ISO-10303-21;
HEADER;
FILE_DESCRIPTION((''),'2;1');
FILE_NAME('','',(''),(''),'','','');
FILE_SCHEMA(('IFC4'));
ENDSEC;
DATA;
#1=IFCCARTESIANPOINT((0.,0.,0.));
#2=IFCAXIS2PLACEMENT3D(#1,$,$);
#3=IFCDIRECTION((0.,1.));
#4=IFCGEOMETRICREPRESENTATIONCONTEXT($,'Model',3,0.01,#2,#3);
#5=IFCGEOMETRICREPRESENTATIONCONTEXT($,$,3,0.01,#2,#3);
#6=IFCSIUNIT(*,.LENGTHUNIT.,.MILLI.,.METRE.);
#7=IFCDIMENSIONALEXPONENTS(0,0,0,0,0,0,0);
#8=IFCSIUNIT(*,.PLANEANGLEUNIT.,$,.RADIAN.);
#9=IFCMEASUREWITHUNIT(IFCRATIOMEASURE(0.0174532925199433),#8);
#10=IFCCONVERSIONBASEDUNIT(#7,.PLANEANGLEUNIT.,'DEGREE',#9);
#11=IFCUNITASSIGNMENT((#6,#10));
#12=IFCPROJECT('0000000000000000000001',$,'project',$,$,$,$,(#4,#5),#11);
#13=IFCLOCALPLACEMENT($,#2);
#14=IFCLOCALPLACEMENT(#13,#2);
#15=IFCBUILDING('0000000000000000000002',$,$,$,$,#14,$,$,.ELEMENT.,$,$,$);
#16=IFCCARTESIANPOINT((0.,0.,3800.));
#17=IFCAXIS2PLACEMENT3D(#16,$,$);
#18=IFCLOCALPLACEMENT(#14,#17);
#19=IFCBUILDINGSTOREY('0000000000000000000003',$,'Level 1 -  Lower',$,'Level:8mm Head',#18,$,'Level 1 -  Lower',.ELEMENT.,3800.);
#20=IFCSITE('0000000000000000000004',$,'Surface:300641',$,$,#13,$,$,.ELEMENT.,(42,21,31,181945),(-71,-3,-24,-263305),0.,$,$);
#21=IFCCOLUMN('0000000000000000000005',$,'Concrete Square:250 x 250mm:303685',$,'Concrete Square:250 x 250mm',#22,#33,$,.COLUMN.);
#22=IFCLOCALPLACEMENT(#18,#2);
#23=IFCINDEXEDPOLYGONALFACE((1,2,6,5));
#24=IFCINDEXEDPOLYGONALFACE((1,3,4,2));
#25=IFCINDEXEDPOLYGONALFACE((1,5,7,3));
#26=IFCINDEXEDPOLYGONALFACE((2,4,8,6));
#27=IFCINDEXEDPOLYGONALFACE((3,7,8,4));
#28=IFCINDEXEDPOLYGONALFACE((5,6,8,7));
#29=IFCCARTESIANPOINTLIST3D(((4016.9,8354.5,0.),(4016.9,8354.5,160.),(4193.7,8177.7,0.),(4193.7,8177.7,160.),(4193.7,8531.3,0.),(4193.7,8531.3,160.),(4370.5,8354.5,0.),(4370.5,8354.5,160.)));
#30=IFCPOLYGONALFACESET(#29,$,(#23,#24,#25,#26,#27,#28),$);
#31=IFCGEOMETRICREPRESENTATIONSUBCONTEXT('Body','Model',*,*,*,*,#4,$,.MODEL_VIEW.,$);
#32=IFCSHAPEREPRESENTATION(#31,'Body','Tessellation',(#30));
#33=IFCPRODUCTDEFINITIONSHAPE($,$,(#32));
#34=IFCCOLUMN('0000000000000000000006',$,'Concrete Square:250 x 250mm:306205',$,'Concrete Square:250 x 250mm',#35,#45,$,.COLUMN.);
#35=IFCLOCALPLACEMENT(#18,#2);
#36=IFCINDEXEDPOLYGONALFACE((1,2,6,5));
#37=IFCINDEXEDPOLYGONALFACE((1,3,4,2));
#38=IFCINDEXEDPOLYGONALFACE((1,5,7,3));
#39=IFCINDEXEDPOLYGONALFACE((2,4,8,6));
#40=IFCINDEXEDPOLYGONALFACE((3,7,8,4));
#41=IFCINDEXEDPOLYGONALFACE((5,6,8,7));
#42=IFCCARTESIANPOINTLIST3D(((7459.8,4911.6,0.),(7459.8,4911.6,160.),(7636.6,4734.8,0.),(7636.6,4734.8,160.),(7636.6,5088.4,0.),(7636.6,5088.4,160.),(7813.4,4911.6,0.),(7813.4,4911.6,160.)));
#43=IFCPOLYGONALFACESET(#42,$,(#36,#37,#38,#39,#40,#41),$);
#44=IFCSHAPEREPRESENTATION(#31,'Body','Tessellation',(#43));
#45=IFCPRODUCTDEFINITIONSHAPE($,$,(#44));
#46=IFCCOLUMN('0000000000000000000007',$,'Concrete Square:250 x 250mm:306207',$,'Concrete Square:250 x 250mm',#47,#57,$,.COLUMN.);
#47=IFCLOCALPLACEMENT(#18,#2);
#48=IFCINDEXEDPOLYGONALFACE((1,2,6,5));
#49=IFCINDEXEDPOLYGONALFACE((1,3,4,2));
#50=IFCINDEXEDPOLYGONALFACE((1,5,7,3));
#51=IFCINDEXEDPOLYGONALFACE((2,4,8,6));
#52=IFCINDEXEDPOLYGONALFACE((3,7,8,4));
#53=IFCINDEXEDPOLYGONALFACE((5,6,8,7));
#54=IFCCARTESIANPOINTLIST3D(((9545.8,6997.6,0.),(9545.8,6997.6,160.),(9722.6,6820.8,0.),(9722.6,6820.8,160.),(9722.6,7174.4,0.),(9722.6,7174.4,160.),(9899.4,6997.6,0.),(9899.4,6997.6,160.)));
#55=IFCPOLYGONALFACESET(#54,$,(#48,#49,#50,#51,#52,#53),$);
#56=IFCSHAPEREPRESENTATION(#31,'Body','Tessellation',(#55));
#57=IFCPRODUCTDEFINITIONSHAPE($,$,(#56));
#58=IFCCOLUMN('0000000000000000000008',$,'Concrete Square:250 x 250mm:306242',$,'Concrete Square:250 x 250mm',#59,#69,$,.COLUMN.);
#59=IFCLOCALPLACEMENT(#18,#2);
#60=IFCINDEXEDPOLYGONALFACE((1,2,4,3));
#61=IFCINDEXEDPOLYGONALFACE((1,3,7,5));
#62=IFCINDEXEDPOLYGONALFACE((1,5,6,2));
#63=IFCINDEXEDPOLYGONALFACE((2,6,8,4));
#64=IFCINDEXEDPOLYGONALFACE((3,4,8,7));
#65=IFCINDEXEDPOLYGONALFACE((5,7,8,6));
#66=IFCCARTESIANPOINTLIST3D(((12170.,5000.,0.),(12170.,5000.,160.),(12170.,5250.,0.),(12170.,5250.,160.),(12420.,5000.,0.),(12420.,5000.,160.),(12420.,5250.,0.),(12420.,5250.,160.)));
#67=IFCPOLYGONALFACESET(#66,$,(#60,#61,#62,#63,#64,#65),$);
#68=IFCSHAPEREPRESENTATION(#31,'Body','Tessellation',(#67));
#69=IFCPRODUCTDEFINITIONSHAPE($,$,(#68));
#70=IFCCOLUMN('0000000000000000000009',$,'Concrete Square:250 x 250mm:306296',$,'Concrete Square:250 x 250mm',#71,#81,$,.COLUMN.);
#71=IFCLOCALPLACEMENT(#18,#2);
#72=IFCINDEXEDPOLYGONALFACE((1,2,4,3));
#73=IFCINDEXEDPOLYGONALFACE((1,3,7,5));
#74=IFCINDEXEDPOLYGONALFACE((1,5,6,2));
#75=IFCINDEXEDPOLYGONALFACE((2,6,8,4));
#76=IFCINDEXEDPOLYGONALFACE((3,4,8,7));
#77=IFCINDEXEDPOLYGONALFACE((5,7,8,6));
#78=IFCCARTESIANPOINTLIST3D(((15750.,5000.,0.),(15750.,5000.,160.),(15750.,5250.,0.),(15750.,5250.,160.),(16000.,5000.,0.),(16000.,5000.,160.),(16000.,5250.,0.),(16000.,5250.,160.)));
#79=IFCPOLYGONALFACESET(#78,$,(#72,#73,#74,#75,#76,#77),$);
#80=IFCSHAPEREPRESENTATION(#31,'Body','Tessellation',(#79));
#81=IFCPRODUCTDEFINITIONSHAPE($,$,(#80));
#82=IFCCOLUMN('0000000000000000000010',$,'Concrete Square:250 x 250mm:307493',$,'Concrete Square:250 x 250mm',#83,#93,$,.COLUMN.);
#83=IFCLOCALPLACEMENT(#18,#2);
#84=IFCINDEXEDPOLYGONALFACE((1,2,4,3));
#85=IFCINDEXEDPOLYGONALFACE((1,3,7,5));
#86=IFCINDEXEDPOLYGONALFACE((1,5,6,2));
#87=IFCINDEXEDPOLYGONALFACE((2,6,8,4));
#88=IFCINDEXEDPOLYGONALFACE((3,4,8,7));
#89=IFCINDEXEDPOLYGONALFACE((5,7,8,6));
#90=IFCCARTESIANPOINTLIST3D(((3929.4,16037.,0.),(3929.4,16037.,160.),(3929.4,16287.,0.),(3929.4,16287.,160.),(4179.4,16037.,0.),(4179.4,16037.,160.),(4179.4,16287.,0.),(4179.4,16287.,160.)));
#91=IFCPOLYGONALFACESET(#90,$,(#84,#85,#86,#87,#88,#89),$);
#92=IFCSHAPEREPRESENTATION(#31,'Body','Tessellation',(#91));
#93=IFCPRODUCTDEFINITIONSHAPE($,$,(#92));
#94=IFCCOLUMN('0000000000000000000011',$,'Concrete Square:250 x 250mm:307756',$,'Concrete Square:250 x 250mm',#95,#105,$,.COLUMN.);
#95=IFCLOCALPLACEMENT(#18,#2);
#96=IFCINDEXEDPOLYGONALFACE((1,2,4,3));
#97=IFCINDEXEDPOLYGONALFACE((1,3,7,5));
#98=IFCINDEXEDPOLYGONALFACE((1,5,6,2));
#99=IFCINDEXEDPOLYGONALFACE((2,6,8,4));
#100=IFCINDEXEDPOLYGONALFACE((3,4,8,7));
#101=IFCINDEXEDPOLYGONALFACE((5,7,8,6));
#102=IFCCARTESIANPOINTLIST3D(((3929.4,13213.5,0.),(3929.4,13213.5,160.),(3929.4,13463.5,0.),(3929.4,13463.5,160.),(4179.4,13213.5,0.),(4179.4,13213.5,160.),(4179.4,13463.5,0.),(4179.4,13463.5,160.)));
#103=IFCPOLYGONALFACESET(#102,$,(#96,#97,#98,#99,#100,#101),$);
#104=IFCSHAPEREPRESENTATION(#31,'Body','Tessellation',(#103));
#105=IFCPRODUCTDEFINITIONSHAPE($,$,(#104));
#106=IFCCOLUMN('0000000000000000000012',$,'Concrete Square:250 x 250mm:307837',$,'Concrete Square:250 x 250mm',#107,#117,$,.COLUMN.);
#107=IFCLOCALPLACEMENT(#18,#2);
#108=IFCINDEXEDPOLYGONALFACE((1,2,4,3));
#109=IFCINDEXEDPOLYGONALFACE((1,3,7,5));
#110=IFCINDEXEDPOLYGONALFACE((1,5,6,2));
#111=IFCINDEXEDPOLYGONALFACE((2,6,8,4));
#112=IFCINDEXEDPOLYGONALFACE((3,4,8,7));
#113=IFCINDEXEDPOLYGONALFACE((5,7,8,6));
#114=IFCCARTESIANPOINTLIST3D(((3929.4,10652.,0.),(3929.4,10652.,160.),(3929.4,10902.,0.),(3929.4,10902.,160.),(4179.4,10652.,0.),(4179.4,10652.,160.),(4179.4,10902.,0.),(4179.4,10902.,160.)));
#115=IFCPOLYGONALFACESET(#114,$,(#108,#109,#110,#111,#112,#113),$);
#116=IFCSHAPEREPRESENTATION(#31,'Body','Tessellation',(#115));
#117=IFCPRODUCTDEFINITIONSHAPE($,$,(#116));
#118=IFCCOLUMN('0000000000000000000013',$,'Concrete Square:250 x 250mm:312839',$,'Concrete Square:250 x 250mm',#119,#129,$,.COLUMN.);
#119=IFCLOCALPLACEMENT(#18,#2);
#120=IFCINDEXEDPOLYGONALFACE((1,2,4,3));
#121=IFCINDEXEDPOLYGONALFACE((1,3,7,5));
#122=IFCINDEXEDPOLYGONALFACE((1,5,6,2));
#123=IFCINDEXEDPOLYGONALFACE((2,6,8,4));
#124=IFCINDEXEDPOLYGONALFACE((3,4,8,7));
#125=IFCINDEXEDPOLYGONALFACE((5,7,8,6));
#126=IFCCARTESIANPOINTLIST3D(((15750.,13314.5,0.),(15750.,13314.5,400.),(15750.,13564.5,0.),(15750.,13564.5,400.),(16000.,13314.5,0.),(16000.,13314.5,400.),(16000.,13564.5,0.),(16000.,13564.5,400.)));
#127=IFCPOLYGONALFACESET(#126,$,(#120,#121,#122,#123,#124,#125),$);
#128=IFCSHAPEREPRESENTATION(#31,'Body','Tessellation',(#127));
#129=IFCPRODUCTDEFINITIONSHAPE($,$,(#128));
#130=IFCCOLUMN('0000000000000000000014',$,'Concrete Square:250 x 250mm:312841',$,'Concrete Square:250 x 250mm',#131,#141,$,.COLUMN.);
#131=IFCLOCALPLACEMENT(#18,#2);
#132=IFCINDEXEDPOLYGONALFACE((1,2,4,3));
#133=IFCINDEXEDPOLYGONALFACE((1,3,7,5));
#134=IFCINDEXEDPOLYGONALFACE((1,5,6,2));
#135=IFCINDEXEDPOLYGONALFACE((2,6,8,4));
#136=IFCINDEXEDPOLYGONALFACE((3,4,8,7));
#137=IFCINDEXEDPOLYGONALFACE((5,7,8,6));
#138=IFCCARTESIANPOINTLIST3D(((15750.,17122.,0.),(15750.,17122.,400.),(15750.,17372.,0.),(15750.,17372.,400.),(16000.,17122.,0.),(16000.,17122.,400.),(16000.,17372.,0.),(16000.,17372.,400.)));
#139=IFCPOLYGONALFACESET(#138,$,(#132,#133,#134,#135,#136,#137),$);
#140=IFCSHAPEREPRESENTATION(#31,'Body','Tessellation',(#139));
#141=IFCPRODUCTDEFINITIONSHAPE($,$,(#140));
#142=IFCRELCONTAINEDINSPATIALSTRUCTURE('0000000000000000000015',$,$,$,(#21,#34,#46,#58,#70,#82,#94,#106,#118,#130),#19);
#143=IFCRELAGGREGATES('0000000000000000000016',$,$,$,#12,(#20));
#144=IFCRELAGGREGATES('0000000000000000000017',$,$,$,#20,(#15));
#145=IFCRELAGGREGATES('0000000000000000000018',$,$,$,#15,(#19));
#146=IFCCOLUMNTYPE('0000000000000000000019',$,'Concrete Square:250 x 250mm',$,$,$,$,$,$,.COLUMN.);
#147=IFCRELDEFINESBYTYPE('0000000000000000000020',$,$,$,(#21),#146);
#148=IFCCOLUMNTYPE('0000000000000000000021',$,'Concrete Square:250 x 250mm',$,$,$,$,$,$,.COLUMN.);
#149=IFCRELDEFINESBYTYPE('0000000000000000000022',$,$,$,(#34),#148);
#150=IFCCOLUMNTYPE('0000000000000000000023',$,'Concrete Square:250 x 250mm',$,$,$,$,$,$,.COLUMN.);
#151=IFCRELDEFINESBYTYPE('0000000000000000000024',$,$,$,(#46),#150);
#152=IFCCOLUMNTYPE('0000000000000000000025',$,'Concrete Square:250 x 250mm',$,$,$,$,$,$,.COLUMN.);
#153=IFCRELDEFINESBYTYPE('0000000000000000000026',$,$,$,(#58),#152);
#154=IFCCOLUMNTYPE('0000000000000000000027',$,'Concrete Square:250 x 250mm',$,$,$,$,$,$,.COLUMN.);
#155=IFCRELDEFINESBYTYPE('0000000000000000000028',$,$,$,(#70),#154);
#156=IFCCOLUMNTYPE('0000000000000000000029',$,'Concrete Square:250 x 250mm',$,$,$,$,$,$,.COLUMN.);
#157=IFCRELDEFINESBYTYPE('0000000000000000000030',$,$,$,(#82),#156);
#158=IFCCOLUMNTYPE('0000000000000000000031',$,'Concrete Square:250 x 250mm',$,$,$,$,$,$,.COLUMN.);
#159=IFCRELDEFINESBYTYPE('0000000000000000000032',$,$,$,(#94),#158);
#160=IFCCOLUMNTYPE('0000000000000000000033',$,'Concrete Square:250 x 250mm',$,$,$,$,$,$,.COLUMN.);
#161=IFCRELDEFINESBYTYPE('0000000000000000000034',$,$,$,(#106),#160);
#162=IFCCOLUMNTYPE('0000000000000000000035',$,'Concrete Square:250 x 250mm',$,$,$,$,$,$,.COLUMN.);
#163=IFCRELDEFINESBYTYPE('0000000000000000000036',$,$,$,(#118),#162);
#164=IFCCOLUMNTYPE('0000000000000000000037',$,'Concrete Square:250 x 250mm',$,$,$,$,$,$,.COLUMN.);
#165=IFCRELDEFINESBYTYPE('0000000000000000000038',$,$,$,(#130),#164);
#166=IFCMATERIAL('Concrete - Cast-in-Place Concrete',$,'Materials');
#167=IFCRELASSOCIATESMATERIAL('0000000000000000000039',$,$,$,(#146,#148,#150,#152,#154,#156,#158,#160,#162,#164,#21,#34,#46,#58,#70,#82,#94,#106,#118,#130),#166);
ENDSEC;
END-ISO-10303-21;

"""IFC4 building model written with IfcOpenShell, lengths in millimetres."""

from ifc_helpers import new_model, entity, si_unit, converted_unit, direction, frame, frame_2d, origin, origin_2d_with_axis, place, context, subcontext, project, spatial, rectangle, extrude, source, transform, mapped, material, material_profile, profile_set, profile_usage, type_object, type_shapes, element, save


model = new_model("IFC4")

# Units and contexts
model_context = context("Model", 3, precision=0.01, world=origin(), true_north=direction((0.0, 1.0)))
context_of_model = context(None, 3, precision=0.01, world=origin(), true_north=direction((0.0, 1.0)))
body_context = subcontext(model_context, "Body", "Model", "MODEL_VIEW")
ifc_project = project(units=[si_unit("LENGTHUNIT", "METRE", prefix="MILLI"), converted_unit("PLANEANGLEUNIT", "DEGREE", entity("IfcRatioMeasure", 0.0174532925199433), si_unit("PLANEANGLEUNIT", "RADIAN"), dimensions=[0, 0, 0, 0, 0, 0, 0])], contexts=[model_context, context_of_model])

# Site, building, storey
site_placement = place(None, origin())
site = spatial("IfcSite", under=ifc_project, at=site_placement, Name="Surface:300641", CompositionType="ELEMENT", RefLatitude=(42, 21, 31, 181945), RefLongitude=(-71, -3, -24, -263305), RefElevation=0.0)
building_placement = place(site_placement, origin())
building = spatial("IfcBuilding", under=site, at=building_placement, CompositionType="ELEMENT")
storey_placement = place(building_placement, frame((0.0, 0.0, 3800.0)))
storey = spatial("IfcBuildingStorey", under=building, at=storey_placement, Name="Level 1 -  Lower", ObjectType="Level:8mm Head", LongName="Level 1 -  Lower", CompositionType="ELEMENT", Elevation=3800.0)

# Columns
ifc_material_1 = material(Name="Concrete - Cast-in-Place Concrete", Category="Materials")
ifc_material_profile_1 = material_profile(ifc_material_1, rectangle(XDim=250.0, YDim=250.0, at=frame_2d((0.0, 0.0), x_axis=(1.0, 0.0))), Name="250 x 250mm")
ifc_profile_set_1 = profile_set([ifc_material_profile_1], Name="250 x 250mm")
ifc_profile_usage_1 = profile_usage(ifc_profile_set_1)
column_type_1 = type_object("IfcColumnType", Name="Concrete Square:250 x 250mm", PredefinedType="COLUMN", material=ifc_profile_set_1)
shared_shape_1 = source(origin(), body_context, "Body", "SweptSolid", [
    extrude(rectangle(XDim=250.0, YDim=250.0, at=frame_2d((0.0, 0.0), x_axis=(1.0, 0.0))), frame((4193.7, 8354.5, 3800.0), z_axis=(0.0, 0.0, 1.0), x_axis=(-0.707107, 0.707107, 0.0)), (0.0, 0.0, 1.0), 160.0),
])
type_shapes(column_type_1, [shared_shape_1])
column_1_placement = place(storey_placement, frame((0.0, 0.0, -3800.0)))
element("IfcColumn", 1, at=column_1_placement, inside=storey, type_object=column_type_1, material=ifc_profile_usage_1, Name="Concrete Square:250 x 250mm:303685", ObjectType="Concrete Square:250 x 250mm", PredefinedType="COLUMN", context=body_context, shape_type="MappedRepresentation", body=[
    mapped(shared_shape_1, transform((0.0, 0.0, 0.0), scale=1.0)),
])
ifc_profile_usage_2 = profile_usage(ifc_profile_set_1)
column_type_2 = type_object("IfcColumnType", Name="Concrete Square:250 x 250mm", PredefinedType="COLUMN", material=ifc_profile_set_1)
shared_shape_2 = source(origin(), body_context, "Body", "SweptSolid", [
    extrude(rectangle(XDim=250.0, YDim=250.0, at=frame_2d((0.0, 0.0), x_axis=(1.0, 0.0))), frame((7636.6, 4911.6, 3800.0), z_axis=(0.0, 0.0, 1.0), x_axis=(-0.707107, 0.707107, 0.0)), (0.0, 0.0, 1.0), 160.0),
])
type_shapes(column_type_2, [shared_shape_2])
column_2_placement = place(storey_placement, frame((0.0, 0.0, -3800.0)))
element("IfcColumn", 2, at=column_2_placement, inside=storey, type_object=column_type_2, material=ifc_profile_usage_2, Name="Concrete Square:250 x 250mm:306205", ObjectType="Concrete Square:250 x 250mm", PredefinedType="COLUMN", context=body_context, shape_type="MappedRepresentation", body=[
    mapped(shared_shape_2, transform((0.0, 0.0, 0.0), scale=1.0)),
])
ifc_profile_usage_3 = profile_usage(ifc_profile_set_1)
column_type_3 = type_object("IfcColumnType", Name="Concrete Square:250 x 250mm", PredefinedType="COLUMN", material=ifc_profile_set_1)
shared_shape_3 = source(origin(), body_context, "Body", "SweptSolid", [
    extrude(rectangle(XDim=250.0, YDim=250.0, at=frame_2d((0.0, 0.0), x_axis=(1.0, 0.0))), frame((9722.6, 6997.6, 3800.0), z_axis=(0.0, 0.0, 1.0), x_axis=(-0.707107, 0.707107, 0.0)), (0.0, 0.0, 1.0), 160.0),
])
type_shapes(column_type_3, [shared_shape_3])
column_3_placement = place(storey_placement, frame((0.0, 0.0, -3800.0)))
element("IfcColumn", 3, at=column_3_placement, inside=storey, type_object=column_type_3, material=ifc_profile_usage_3, Name="Concrete Square:250 x 250mm:306207", ObjectType="Concrete Square:250 x 250mm", PredefinedType="COLUMN", context=body_context, shape_type="MappedRepresentation", body=[
    mapped(shared_shape_3, transform((0.0, 0.0, 0.0), scale=1.0)),
])
ifc_profile_usage_4 = profile_usage(ifc_profile_set_1)
column_type_4 = type_object("IfcColumnType", Name="Concrete Square:250 x 250mm", PredefinedType="COLUMN", material=ifc_profile_set_1)
shared_shape_4 = source(origin(), body_context, "Body", "SweptSolid", [
    extrude(rectangle(XDim=250.0, YDim=250.0, at=origin_2d_with_axis()), frame((12295.0, 5125.0, 3800.0), z_axis=(0.0, 0.0, 1.0), x_axis=(0.0, -1.0, 0.0)), (0.0, 0.0, 1.0), 160.0),
])
type_shapes(column_type_4, [shared_shape_4])
column_4_placement = place(storey_placement, frame((0.0, 0.0, -3800.0)))
element("IfcColumn", 4, at=column_4_placement, inside=storey, type_object=column_type_4, material=ifc_profile_usage_4, Name="Concrete Square:250 x 250mm:306242", ObjectType="Concrete Square:250 x 250mm", PredefinedType="COLUMN", context=body_context, shape_type="MappedRepresentation", body=[
    mapped(shared_shape_4, transform((0.0, 0.0, 0.0), scale=1.0)),
])
ifc_profile_usage_5 = profile_usage(ifc_profile_set_1)
column_type_5 = type_object("IfcColumnType", Name="Concrete Square:250 x 250mm", PredefinedType="COLUMN", material=ifc_profile_set_1)
shared_shape_5 = source(origin(), body_context, "Body", "SweptSolid", [
    extrude(rectangle(XDim=250.0, YDim=250.0, at=origin_2d_with_axis()), frame((15875.0, 5125.0, 3800.0), z_axis=(0.0, 0.0, 1.0), x_axis=(0.0, -1.0, 0.0)), (0.0, 0.0, 1.0), 160.0),
])
type_shapes(column_type_5, [shared_shape_5])
column_5_placement = place(storey_placement, frame((0.0, 0.0, -3800.0)))
element("IfcColumn", 5, at=column_5_placement, inside=storey, type_object=column_type_5, material=ifc_profile_usage_5, Name="Concrete Square:250 x 250mm:306296", ObjectType="Concrete Square:250 x 250mm", PredefinedType="COLUMN", context=body_context, shape_type="MappedRepresentation", body=[
    mapped(shared_shape_5, transform((0.0, 0.0, 0.0), scale=1.0)),
])
ifc_profile_usage_6 = profile_usage(ifc_profile_set_1)
column_type_6 = type_object("IfcColumnType", Name="Concrete Square:250 x 250mm", PredefinedType="COLUMN", material=ifc_profile_set_1)
shared_shape_6 = source(origin(), body_context, "Body", "SweptSolid", [
    extrude(rectangle(XDim=250.0, YDim=250.0, at=frame_2d((0.0, 0.0), x_axis=(1.0, 0.0))), frame((4054.4, 16162.0, 3800.0), z_axis=(0.0, 0.0, 1.0), x_axis=(0.0, -1.0, 0.0)), (0.0, 0.0, 1.0), 160.0),
])
type_shapes(column_type_6, [shared_shape_6])
column_6_placement = place(storey_placement, frame((0.0, 0.0, -3800.0)))
element("IfcColumn", 6, at=column_6_placement, inside=storey, type_object=column_type_6, material=ifc_profile_usage_6, Name="Concrete Square:250 x 250mm:307493", ObjectType="Concrete Square:250 x 250mm", PredefinedType="COLUMN", context=body_context, shape_type="MappedRepresentation", body=[
    mapped(shared_shape_6, transform((0.0, 0.0, 0.0), scale=1.0)),
])
ifc_profile_usage_7 = profile_usage(ifc_profile_set_1)
column_type_7 = type_object("IfcColumnType", Name="Concrete Square:250 x 250mm", PredefinedType="COLUMN", material=ifc_profile_set_1)
shared_shape_7 = source(origin(), body_context, "Body", "SweptSolid", [
    extrude(rectangle(XDim=250.0, YDim=250.0, at=frame_2d((0.0, 0.0), x_axis=(1.0, 0.0))), frame((4054.4, 13338.5, 3800.0), z_axis=(0.0, 0.0, 1.0), x_axis=(0.0, -1.0, 0.0)), (0.0, 0.0, 1.0), 160.0),
])
type_shapes(column_type_7, [shared_shape_7])
column_7_placement = place(storey_placement, frame((0.0, 0.0, -3800.0)))
element("IfcColumn", 7, at=column_7_placement, inside=storey, type_object=column_type_7, material=ifc_profile_usage_7, Name="Concrete Square:250 x 250mm:307756", ObjectType="Concrete Square:250 x 250mm", PredefinedType="COLUMN", context=body_context, shape_type="MappedRepresentation", body=[
    mapped(shared_shape_7, transform((0.0, 0.0, 0.0), scale=1.0)),
])
ifc_profile_usage_8 = profile_usage(ifc_profile_set_1)
column_type_8 = type_object("IfcColumnType", Name="Concrete Square:250 x 250mm", PredefinedType="COLUMN", material=ifc_profile_set_1)
shared_shape_8 = source(origin(), body_context, "Body", "SweptSolid", [
    extrude(rectangle(XDim=250.0, YDim=250.0, at=frame_2d((0.0, 0.0), x_axis=(1.0, 0.0))), frame((4054.4, 10777.0, 3800.0), z_axis=(0.0, 0.0, 1.0), x_axis=(0.0, -1.0, 0.0)), (0.0, 0.0, 1.0), 160.0),
])
type_shapes(column_type_8, [shared_shape_8])
column_8_placement = place(storey_placement, frame((0.0, 0.0, -3800.0)))
element("IfcColumn", 8, at=column_8_placement, inside=storey, type_object=column_type_8, material=ifc_profile_usage_8, Name="Concrete Square:250 x 250mm:307837", ObjectType="Concrete Square:250 x 250mm", PredefinedType="COLUMN", context=body_context, shape_type="MappedRepresentation", body=[
    mapped(shared_shape_8, transform((0.0, 0.0, 0.0), scale=1.0)),
])
ifc_profile_usage_9 = profile_usage(ifc_profile_set_1)
column_type_9 = type_object("IfcColumnType", Name="Concrete Square:250 x 250mm", PredefinedType="COLUMN", material=ifc_profile_set_1)
shared_shape_9 = source(origin(), body_context, "Body", "SweptSolid", [
    extrude(rectangle(XDim=250.0, YDim=250.0, at=frame_2d((0.0, 0.0), x_axis=(1.0, 0.0))), frame((15875.0, 13439.5, 3800.0), z_axis=(0.0, 0.0, 1.0), x_axis=(0.0, -1.0, 0.0)), (0.0, 0.0, 1.0), 400.0),
])
type_shapes(column_type_9, [shared_shape_9])
column_9_placement = place(storey_placement, frame((0.0, 0.0, -3800.0)))
element("IfcColumn", 9, at=column_9_placement, inside=storey, type_object=column_type_9, material=ifc_profile_usage_9, Name="Concrete Square:250 x 250mm:312839", ObjectType="Concrete Square:250 x 250mm", PredefinedType="COLUMN", context=body_context, shape_type="MappedRepresentation", body=[
    mapped(shared_shape_9, transform((0.0, 0.0, 0.0), scale=1.0)),
])
ifc_profile_usage_10 = profile_usage(ifc_profile_set_1)
column_type_10 = type_object("IfcColumnType", Name="Concrete Square:250 x 250mm", PredefinedType="COLUMN", material=ifc_profile_set_1)
shared_shape_10 = source(origin(), body_context, "Body", "SweptSolid", [
    extrude(rectangle(XDim=250.0, YDim=250.0, at=origin_2d_with_axis()), frame((15875.0, 17247.0, 3800.0), z_axis=(0.0, 0.0, 1.0), x_axis=(0.0, -1.0, 0.0)), (0.0, 0.0, 1.0), 400.0),
])
type_shapes(column_type_10, [shared_shape_10])
column_10_placement = place(storey_placement, frame((0.0, 0.0, -3800.0)))
element("IfcColumn", 10, at=column_10_placement, inside=storey, type_object=column_type_10, material=ifc_profile_usage_10, Name="Concrete Square:250 x 250mm:312841", ObjectType="Concrete Square:250 x 250mm", PredefinedType="COLUMN", context=body_context, shape_type="MappedRepresentation", body=[
    mapped(shared_shape_10, transform((0.0, 0.0, 0.0), scale=1.0)),
])

save(model, "model.ifc")
